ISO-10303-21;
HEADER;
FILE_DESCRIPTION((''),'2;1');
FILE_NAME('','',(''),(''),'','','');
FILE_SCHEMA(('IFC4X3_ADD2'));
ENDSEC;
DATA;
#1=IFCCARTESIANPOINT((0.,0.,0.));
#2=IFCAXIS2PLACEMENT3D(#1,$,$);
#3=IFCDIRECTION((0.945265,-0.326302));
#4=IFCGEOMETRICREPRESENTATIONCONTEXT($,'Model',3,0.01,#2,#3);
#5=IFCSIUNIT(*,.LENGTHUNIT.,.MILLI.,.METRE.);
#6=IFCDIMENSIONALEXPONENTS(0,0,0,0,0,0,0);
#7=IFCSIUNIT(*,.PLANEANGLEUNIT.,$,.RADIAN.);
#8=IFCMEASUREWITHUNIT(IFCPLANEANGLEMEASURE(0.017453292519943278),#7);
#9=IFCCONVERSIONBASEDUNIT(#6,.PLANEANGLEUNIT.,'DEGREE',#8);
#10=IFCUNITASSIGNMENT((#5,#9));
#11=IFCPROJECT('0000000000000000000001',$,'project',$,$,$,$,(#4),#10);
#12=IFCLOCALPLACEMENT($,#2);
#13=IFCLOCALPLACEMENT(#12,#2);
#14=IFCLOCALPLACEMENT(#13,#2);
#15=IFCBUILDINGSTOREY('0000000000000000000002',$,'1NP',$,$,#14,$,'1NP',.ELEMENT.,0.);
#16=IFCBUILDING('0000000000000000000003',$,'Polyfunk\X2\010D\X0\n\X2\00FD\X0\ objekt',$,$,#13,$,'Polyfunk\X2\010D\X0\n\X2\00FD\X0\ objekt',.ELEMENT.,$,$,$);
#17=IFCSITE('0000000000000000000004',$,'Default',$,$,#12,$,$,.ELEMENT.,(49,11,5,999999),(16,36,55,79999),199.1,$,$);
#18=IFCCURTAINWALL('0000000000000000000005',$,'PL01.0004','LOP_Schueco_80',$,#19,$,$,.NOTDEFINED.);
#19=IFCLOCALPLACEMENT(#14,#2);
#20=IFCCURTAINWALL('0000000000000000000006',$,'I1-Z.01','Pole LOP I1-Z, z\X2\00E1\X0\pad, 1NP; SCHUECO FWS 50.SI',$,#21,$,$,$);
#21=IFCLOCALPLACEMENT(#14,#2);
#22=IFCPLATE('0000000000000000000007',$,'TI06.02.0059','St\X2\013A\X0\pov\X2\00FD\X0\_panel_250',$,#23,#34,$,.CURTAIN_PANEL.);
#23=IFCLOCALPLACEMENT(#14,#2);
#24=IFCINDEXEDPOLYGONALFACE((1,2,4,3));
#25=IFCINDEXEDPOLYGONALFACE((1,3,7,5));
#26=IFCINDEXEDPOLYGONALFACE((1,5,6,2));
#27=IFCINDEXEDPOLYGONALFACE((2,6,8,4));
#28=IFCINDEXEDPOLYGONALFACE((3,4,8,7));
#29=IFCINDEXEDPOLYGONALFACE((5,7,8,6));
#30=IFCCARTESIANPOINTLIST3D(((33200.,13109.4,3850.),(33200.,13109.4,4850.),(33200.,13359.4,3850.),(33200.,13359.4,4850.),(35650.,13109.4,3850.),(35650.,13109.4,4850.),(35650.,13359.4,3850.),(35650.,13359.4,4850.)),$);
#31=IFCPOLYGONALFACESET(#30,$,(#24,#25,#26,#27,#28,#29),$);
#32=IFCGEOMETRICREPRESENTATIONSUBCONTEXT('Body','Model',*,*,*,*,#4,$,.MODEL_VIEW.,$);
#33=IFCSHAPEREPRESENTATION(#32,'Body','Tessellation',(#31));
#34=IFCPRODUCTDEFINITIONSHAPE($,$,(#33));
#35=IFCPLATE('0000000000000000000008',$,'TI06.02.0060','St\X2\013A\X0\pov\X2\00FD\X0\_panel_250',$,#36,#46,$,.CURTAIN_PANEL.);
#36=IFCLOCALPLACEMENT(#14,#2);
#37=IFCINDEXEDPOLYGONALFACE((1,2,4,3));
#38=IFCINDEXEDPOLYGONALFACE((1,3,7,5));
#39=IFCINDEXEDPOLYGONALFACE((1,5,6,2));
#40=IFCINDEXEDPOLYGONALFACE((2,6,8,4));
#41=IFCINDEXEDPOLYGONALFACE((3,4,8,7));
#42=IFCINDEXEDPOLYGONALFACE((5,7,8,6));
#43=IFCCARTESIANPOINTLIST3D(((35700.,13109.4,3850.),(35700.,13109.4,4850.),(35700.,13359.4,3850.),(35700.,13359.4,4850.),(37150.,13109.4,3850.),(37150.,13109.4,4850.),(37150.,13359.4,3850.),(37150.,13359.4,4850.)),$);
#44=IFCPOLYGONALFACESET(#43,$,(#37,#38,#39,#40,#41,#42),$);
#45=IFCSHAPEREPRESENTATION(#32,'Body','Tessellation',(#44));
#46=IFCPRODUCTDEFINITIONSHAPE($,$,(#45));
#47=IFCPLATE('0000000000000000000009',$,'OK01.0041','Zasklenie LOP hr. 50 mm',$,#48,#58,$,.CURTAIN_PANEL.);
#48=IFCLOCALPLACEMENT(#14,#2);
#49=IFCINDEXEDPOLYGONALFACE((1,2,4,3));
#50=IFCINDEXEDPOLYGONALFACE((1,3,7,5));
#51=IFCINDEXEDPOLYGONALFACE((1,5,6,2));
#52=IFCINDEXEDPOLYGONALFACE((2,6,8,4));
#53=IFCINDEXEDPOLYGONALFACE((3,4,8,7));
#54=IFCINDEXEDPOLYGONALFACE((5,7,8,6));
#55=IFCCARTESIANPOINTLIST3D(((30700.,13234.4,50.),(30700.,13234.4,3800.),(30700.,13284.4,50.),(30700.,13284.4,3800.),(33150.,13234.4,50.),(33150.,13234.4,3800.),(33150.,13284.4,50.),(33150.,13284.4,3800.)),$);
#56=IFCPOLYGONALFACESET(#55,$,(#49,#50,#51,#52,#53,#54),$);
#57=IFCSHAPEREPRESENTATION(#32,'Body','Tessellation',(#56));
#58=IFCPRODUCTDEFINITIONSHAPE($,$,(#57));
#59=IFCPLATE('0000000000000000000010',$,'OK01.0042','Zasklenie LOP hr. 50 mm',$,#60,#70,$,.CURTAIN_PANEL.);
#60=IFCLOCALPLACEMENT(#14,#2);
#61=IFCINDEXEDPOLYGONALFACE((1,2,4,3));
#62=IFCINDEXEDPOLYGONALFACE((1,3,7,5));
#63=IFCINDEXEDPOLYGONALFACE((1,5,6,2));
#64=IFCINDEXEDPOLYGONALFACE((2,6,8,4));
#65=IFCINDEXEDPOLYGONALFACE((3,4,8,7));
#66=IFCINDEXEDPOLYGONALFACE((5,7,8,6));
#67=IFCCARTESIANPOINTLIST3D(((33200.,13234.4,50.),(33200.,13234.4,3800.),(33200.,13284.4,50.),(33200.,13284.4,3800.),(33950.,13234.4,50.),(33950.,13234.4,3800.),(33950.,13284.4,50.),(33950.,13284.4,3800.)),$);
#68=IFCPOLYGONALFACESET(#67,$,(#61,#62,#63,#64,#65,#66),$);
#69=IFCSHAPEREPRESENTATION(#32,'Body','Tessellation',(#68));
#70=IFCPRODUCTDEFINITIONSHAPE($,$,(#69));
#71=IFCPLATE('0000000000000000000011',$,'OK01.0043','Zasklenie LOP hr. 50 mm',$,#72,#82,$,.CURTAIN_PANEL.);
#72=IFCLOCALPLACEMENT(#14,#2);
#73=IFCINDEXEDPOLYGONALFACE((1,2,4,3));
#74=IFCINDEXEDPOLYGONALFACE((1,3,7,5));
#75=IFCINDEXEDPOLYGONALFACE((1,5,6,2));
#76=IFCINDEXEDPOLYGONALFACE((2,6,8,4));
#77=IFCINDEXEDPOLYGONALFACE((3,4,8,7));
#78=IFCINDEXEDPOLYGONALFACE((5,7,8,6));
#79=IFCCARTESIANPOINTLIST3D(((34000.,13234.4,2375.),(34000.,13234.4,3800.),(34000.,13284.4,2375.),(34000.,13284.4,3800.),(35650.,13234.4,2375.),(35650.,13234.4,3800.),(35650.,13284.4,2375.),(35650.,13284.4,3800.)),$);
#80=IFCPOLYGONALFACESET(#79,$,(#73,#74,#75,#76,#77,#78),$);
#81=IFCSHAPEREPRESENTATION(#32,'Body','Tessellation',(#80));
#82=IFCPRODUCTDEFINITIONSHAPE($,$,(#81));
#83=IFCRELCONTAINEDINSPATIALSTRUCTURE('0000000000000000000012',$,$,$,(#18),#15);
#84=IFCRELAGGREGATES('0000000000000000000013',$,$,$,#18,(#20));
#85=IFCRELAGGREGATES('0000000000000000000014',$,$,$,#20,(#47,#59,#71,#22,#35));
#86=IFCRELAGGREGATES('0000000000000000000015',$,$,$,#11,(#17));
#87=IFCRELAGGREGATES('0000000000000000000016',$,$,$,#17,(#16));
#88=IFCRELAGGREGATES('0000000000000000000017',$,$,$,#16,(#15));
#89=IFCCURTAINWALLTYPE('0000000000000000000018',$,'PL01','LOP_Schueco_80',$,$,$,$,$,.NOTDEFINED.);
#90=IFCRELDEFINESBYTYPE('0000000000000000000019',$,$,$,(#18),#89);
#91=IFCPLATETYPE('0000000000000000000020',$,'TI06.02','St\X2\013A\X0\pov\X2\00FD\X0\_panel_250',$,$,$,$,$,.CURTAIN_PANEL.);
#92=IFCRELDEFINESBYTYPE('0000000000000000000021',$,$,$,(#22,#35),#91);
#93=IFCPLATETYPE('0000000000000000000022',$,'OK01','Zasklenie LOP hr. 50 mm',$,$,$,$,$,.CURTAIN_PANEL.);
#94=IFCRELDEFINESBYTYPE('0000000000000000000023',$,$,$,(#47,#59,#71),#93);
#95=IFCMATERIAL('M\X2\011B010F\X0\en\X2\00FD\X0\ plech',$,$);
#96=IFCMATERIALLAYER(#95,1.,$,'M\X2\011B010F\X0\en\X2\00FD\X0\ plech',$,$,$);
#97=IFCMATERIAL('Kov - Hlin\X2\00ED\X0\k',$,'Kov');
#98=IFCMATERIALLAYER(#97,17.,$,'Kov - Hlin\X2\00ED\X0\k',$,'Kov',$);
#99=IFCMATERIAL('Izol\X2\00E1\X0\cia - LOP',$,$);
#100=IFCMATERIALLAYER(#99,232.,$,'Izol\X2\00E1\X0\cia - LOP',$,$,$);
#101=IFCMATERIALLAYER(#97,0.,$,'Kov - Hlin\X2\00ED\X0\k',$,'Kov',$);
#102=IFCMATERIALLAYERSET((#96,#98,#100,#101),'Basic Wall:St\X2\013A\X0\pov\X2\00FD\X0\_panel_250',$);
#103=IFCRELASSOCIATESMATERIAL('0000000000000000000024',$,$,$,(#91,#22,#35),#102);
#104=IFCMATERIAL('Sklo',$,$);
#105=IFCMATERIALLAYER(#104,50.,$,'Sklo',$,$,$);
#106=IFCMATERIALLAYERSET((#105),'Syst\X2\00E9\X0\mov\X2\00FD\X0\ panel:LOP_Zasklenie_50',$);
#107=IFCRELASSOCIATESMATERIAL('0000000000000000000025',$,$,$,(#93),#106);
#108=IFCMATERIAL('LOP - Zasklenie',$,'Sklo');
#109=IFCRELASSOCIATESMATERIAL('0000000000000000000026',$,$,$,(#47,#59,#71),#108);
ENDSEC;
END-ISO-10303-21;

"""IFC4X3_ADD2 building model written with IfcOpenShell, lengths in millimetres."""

from ifc_helpers import new_model, entity, si_unit, converted_unit, direction, frame, frame_2d, origin, origin_2d_with_axis, place, context, subcontext, project, spatial, rectangle, extrude, source, transform, mapped, material, layer, layer_set, layer_usage, type_object, type_shapes, element, aggregate, save


model = new_model("IFC4X3_ADD2")

# Units and contexts
model_context = context("Model", 3, precision=0.01, world=origin(), true_north=direction((0.945265, -0.326302)))
body_context = subcontext(model_context, "Body", "Model", "MODEL_VIEW")
ifc_project = project(units=[si_unit("LENGTHUNIT", "METRE", prefix="MILLI"), converted_unit("PLANEANGLEUNIT", "DEGREE", entity("IfcPlaneAngleMeasure", 0.017453292519943278), si_unit("PLANEANGLEUNIT", "RADIAN"), dimensions=[0, 0, 0, 0, 0, 0, 0])], contexts=[model_context])

# Site, building, storey
site_placement = place(None, origin())
site = spatial("IfcSite", under=ifc_project, at=site_placement, Name="Default", CompositionType="ELEMENT", RefLatitude=(49, 11, 5, 999999), RefLongitude=(16, 36, 55, 79999), RefElevation=199.1)
building_placement = place(site_placement, origin())
building = spatial("IfcBuilding", under=site, at=building_placement, Name="Polyfunkčný objekt", LongName="Polyfunkčný objekt", CompositionType="ELEMENT")
storey_placement = place(building_placement, origin())
storey = spatial("IfcBuildingStorey", under=building, at=storey_placement, Name="1NP", LongName="1NP", CompositionType="ELEMENT", Elevation=0.0)

# Curtain walls, plates
curtain_wall_type = type_object("IfcCurtainWallType", Name="PL01", Description="LOP_Schueco_80", PredefinedType="NOTDEFINED")
curtain_wall_1_placement = place(storey_placement, origin())
curtain_wall_1 = element("IfcCurtainWall", 1, at=curtain_wall_1_placement, inside=storey, type_object=curtain_wall_type, Name="PL01.0004", Description="LOP_Schueco_80", PredefinedType="NOTDEFINED")
curtain_wall_2 = element("IfcCurtainWall", 2, Name="I1-Z.01", Description="Pole LOP I1-Z, západ, 1NP; SCHUECO FWS 50.SI")
aggregate(curtain_wall_1, [curtain_wall_2])
ifc_material_1 = material(Name="Měďený plech")
ifc_layer_1 = layer(ifc_material_1, 1.0, Name="Měďený plech")
ifc_material_2 = material(Name="Kov - Hliník", Category="Kov")
ifc_layer_2 = layer(ifc_material_2, 17.0, Name="Kov - Hliník", Category="Kov")
ifc_material_3 = material(Name="Izolácia - LOP")
ifc_layer_3 = layer(ifc_material_3, 232.0, Name="Izolácia - LOP")
ifc_layer_4 = layer(ifc_material_2, 0.0, Name="Kov - Hliník", Category="Kov")
ifc_layer_set_1 = layer_set([ifc_layer_1, ifc_layer_2, ifc_layer_3, ifc_layer_4], Name="Basic Wall:Stĺpový_panel_250")
ifc_layer_usage_1 = layer_usage(ifc_layer_set_1, "AXIS2", "NEGATIVE", 125.0)
plate_type_1 = type_object("IfcPlateType", Name="TI06.02", Description="Stĺpový_panel_250", PredefinedType="CURTAIN_PANEL", material=ifc_layer_set_1)
plate_1_placement = place(storey_placement, frame((33200.0, 13234.4, 3850.0)))
plate_1 = element("IfcPlate", 3, at=plate_1_placement, type_object=plate_type_1, material=ifc_layer_usage_1, Name="TI06.02.0059", Description="Stĺpový_panel_250", PredefinedType="CURTAIN_PANEL", context=body_context, shape_type="SweptSolid", body=[
    extrude(rectangle(XDim=250.0, YDim=2450.0, at=frame_2d((0.0, 0.0), x_axis=(1.0, 0.0))), frame((1225.0, 0.0, 0.0), z_axis=(0.0, 0.0, 1.0), x_axis=(0.0, 1.0, 0.0)), (0.0, 0.0, 1.0), 1000.0),
])
ifc_layer_usage_2 = layer_usage(ifc_layer_set_1, "AXIS2", "NEGATIVE", 125.0)
plate_2_placement = place(storey_placement, frame((35700.0, 13234.4, 3850.0)))
plate_2 = element("IfcPlate", 4, at=plate_2_placement, type_object=plate_type_1, material=ifc_layer_usage_2, Name="TI06.02.0060", Description="Stĺpový_panel_250", PredefinedType="CURTAIN_PANEL", context=body_context, shape_type="SweptSolid", body=[
    extrude(rectangle(XDim=250.0, YDim=1450.0, at=origin_2d_with_axis()), frame((725.0, 0.0, 0.0), z_axis=(0.0, 0.0, 1.0), x_axis=(0.0, 1.0, 0.0)), (0.0, 0.0, 1.0), 1000.0),
])
ifc_material_4 = material(Name="LOP - Zasklenie", Category="Sklo")
ifc_material_5 = material(Name="Sklo")
ifc_layer_5 = layer(ifc_material_5, 50.0, Name="Sklo")
ifc_layer_set_2 = layer_set([ifc_layer_5], Name="Systémový panel:LOP_Zasklenie_50")
plate_type_2 = type_object("IfcPlateType", Name="OK01", Description="Zasklenie LOP hr. 50 mm", PredefinedType="CURTAIN_PANEL", material=ifc_layer_set_2)
shared_shape_1 = source(origin(), body_context, "Body", "SweptSolid", [
    extrude(rectangle(XDim=3750.0, YDim=2450.0, at=frame_2d((-141.7, 0.0), x_axis=(1.0, 0.0))), frame((0.0, 0.0, 2016.7), z_axis=(0.0, 1.0, 0.0), x_axis=(0.0, 0.0, 1.0)), (0.0, 0.0, 1.0), 50.0),
])
plate_3_placement = place(curtain_wall_1_placement, frame((31925.0, 13234.4, 50.0)))
plate_3 = element("IfcPlate", 5, at=plate_3_placement, type_object=plate_type_2, material=ifc_material_4, Name="OK01.0041", Description="Zasklenie LOP hr. 50 mm", PredefinedType="CURTAIN_PANEL", context=body_context, shape_type="MappedRepresentation", body=[
    mapped(shared_shape_1, transform((0.0, 0.0, 0.0), scale=1.0)),
])
shared_shape_2 = source(origin(), body_context, "Body", "SweptSolid", [
    extrude(rectangle(XDim=3750.0, YDim=750.0, at=frame_2d((-141.7, 0.0), x_axis=(1.0, 0.0))), frame((0.0, 0.0, 2016.7), z_axis=(0.0, 1.0, 0.0), x_axis=(0.0, 0.0, 1.0)), (0.0, 0.0, 1.0), 50.0),
])
plate_4_placement = place(curtain_wall_1_placement, frame((33575.0, 13234.4, 50.0)))
plate_4 = element("IfcPlate", 6, at=plate_4_placement, type_object=plate_type_2, material=ifc_material_4, Name="OK01.0042", Description="Zasklenie LOP hr. 50 mm", PredefinedType="CURTAIN_PANEL", context=body_context, shape_type="MappedRepresentation", body=[
    mapped(shared_shape_2, transform((0.0, 0.0, 0.0), scale=1.0)),
])
shared_shape_3 = source(origin(), body_context, "Body", "SweptSolid", [
    extrude(rectangle(XDim=50.0, YDim=1650.0, at=origin_2d_with_axis()), frame((0.0, 25.0, 0.0), z_axis=(0.0, 0.0, 1.0), x_axis=(0.0, 1.0, 0.0)), (0.0, 0.0, 1.0), 1425.0),
])
type_shapes(plate_type_2, [shared_shape_1, shared_shape_2, shared_shape_3])
plate_5_placement = place(curtain_wall_1_placement, frame((34825.0, 13234.4, 2375.0)))
plate_5 = element("IfcPlate", 7, at=plate_5_placement, type_object=plate_type_2, material=ifc_material_4, Name="OK01.0043", Description="Zasklenie LOP hr. 50 mm", PredefinedType="CURTAIN_PANEL", context=body_context, shape_type="MappedRepresentation", body=[
    mapped(shared_shape_3, transform((0.0, 0.0, 0.0), scale=1.0)),
])
aggregate(curtain_wall_2, [plate_3, plate_4, plate_5, plate_1, plate_2])

save(model, "model.ifc")
